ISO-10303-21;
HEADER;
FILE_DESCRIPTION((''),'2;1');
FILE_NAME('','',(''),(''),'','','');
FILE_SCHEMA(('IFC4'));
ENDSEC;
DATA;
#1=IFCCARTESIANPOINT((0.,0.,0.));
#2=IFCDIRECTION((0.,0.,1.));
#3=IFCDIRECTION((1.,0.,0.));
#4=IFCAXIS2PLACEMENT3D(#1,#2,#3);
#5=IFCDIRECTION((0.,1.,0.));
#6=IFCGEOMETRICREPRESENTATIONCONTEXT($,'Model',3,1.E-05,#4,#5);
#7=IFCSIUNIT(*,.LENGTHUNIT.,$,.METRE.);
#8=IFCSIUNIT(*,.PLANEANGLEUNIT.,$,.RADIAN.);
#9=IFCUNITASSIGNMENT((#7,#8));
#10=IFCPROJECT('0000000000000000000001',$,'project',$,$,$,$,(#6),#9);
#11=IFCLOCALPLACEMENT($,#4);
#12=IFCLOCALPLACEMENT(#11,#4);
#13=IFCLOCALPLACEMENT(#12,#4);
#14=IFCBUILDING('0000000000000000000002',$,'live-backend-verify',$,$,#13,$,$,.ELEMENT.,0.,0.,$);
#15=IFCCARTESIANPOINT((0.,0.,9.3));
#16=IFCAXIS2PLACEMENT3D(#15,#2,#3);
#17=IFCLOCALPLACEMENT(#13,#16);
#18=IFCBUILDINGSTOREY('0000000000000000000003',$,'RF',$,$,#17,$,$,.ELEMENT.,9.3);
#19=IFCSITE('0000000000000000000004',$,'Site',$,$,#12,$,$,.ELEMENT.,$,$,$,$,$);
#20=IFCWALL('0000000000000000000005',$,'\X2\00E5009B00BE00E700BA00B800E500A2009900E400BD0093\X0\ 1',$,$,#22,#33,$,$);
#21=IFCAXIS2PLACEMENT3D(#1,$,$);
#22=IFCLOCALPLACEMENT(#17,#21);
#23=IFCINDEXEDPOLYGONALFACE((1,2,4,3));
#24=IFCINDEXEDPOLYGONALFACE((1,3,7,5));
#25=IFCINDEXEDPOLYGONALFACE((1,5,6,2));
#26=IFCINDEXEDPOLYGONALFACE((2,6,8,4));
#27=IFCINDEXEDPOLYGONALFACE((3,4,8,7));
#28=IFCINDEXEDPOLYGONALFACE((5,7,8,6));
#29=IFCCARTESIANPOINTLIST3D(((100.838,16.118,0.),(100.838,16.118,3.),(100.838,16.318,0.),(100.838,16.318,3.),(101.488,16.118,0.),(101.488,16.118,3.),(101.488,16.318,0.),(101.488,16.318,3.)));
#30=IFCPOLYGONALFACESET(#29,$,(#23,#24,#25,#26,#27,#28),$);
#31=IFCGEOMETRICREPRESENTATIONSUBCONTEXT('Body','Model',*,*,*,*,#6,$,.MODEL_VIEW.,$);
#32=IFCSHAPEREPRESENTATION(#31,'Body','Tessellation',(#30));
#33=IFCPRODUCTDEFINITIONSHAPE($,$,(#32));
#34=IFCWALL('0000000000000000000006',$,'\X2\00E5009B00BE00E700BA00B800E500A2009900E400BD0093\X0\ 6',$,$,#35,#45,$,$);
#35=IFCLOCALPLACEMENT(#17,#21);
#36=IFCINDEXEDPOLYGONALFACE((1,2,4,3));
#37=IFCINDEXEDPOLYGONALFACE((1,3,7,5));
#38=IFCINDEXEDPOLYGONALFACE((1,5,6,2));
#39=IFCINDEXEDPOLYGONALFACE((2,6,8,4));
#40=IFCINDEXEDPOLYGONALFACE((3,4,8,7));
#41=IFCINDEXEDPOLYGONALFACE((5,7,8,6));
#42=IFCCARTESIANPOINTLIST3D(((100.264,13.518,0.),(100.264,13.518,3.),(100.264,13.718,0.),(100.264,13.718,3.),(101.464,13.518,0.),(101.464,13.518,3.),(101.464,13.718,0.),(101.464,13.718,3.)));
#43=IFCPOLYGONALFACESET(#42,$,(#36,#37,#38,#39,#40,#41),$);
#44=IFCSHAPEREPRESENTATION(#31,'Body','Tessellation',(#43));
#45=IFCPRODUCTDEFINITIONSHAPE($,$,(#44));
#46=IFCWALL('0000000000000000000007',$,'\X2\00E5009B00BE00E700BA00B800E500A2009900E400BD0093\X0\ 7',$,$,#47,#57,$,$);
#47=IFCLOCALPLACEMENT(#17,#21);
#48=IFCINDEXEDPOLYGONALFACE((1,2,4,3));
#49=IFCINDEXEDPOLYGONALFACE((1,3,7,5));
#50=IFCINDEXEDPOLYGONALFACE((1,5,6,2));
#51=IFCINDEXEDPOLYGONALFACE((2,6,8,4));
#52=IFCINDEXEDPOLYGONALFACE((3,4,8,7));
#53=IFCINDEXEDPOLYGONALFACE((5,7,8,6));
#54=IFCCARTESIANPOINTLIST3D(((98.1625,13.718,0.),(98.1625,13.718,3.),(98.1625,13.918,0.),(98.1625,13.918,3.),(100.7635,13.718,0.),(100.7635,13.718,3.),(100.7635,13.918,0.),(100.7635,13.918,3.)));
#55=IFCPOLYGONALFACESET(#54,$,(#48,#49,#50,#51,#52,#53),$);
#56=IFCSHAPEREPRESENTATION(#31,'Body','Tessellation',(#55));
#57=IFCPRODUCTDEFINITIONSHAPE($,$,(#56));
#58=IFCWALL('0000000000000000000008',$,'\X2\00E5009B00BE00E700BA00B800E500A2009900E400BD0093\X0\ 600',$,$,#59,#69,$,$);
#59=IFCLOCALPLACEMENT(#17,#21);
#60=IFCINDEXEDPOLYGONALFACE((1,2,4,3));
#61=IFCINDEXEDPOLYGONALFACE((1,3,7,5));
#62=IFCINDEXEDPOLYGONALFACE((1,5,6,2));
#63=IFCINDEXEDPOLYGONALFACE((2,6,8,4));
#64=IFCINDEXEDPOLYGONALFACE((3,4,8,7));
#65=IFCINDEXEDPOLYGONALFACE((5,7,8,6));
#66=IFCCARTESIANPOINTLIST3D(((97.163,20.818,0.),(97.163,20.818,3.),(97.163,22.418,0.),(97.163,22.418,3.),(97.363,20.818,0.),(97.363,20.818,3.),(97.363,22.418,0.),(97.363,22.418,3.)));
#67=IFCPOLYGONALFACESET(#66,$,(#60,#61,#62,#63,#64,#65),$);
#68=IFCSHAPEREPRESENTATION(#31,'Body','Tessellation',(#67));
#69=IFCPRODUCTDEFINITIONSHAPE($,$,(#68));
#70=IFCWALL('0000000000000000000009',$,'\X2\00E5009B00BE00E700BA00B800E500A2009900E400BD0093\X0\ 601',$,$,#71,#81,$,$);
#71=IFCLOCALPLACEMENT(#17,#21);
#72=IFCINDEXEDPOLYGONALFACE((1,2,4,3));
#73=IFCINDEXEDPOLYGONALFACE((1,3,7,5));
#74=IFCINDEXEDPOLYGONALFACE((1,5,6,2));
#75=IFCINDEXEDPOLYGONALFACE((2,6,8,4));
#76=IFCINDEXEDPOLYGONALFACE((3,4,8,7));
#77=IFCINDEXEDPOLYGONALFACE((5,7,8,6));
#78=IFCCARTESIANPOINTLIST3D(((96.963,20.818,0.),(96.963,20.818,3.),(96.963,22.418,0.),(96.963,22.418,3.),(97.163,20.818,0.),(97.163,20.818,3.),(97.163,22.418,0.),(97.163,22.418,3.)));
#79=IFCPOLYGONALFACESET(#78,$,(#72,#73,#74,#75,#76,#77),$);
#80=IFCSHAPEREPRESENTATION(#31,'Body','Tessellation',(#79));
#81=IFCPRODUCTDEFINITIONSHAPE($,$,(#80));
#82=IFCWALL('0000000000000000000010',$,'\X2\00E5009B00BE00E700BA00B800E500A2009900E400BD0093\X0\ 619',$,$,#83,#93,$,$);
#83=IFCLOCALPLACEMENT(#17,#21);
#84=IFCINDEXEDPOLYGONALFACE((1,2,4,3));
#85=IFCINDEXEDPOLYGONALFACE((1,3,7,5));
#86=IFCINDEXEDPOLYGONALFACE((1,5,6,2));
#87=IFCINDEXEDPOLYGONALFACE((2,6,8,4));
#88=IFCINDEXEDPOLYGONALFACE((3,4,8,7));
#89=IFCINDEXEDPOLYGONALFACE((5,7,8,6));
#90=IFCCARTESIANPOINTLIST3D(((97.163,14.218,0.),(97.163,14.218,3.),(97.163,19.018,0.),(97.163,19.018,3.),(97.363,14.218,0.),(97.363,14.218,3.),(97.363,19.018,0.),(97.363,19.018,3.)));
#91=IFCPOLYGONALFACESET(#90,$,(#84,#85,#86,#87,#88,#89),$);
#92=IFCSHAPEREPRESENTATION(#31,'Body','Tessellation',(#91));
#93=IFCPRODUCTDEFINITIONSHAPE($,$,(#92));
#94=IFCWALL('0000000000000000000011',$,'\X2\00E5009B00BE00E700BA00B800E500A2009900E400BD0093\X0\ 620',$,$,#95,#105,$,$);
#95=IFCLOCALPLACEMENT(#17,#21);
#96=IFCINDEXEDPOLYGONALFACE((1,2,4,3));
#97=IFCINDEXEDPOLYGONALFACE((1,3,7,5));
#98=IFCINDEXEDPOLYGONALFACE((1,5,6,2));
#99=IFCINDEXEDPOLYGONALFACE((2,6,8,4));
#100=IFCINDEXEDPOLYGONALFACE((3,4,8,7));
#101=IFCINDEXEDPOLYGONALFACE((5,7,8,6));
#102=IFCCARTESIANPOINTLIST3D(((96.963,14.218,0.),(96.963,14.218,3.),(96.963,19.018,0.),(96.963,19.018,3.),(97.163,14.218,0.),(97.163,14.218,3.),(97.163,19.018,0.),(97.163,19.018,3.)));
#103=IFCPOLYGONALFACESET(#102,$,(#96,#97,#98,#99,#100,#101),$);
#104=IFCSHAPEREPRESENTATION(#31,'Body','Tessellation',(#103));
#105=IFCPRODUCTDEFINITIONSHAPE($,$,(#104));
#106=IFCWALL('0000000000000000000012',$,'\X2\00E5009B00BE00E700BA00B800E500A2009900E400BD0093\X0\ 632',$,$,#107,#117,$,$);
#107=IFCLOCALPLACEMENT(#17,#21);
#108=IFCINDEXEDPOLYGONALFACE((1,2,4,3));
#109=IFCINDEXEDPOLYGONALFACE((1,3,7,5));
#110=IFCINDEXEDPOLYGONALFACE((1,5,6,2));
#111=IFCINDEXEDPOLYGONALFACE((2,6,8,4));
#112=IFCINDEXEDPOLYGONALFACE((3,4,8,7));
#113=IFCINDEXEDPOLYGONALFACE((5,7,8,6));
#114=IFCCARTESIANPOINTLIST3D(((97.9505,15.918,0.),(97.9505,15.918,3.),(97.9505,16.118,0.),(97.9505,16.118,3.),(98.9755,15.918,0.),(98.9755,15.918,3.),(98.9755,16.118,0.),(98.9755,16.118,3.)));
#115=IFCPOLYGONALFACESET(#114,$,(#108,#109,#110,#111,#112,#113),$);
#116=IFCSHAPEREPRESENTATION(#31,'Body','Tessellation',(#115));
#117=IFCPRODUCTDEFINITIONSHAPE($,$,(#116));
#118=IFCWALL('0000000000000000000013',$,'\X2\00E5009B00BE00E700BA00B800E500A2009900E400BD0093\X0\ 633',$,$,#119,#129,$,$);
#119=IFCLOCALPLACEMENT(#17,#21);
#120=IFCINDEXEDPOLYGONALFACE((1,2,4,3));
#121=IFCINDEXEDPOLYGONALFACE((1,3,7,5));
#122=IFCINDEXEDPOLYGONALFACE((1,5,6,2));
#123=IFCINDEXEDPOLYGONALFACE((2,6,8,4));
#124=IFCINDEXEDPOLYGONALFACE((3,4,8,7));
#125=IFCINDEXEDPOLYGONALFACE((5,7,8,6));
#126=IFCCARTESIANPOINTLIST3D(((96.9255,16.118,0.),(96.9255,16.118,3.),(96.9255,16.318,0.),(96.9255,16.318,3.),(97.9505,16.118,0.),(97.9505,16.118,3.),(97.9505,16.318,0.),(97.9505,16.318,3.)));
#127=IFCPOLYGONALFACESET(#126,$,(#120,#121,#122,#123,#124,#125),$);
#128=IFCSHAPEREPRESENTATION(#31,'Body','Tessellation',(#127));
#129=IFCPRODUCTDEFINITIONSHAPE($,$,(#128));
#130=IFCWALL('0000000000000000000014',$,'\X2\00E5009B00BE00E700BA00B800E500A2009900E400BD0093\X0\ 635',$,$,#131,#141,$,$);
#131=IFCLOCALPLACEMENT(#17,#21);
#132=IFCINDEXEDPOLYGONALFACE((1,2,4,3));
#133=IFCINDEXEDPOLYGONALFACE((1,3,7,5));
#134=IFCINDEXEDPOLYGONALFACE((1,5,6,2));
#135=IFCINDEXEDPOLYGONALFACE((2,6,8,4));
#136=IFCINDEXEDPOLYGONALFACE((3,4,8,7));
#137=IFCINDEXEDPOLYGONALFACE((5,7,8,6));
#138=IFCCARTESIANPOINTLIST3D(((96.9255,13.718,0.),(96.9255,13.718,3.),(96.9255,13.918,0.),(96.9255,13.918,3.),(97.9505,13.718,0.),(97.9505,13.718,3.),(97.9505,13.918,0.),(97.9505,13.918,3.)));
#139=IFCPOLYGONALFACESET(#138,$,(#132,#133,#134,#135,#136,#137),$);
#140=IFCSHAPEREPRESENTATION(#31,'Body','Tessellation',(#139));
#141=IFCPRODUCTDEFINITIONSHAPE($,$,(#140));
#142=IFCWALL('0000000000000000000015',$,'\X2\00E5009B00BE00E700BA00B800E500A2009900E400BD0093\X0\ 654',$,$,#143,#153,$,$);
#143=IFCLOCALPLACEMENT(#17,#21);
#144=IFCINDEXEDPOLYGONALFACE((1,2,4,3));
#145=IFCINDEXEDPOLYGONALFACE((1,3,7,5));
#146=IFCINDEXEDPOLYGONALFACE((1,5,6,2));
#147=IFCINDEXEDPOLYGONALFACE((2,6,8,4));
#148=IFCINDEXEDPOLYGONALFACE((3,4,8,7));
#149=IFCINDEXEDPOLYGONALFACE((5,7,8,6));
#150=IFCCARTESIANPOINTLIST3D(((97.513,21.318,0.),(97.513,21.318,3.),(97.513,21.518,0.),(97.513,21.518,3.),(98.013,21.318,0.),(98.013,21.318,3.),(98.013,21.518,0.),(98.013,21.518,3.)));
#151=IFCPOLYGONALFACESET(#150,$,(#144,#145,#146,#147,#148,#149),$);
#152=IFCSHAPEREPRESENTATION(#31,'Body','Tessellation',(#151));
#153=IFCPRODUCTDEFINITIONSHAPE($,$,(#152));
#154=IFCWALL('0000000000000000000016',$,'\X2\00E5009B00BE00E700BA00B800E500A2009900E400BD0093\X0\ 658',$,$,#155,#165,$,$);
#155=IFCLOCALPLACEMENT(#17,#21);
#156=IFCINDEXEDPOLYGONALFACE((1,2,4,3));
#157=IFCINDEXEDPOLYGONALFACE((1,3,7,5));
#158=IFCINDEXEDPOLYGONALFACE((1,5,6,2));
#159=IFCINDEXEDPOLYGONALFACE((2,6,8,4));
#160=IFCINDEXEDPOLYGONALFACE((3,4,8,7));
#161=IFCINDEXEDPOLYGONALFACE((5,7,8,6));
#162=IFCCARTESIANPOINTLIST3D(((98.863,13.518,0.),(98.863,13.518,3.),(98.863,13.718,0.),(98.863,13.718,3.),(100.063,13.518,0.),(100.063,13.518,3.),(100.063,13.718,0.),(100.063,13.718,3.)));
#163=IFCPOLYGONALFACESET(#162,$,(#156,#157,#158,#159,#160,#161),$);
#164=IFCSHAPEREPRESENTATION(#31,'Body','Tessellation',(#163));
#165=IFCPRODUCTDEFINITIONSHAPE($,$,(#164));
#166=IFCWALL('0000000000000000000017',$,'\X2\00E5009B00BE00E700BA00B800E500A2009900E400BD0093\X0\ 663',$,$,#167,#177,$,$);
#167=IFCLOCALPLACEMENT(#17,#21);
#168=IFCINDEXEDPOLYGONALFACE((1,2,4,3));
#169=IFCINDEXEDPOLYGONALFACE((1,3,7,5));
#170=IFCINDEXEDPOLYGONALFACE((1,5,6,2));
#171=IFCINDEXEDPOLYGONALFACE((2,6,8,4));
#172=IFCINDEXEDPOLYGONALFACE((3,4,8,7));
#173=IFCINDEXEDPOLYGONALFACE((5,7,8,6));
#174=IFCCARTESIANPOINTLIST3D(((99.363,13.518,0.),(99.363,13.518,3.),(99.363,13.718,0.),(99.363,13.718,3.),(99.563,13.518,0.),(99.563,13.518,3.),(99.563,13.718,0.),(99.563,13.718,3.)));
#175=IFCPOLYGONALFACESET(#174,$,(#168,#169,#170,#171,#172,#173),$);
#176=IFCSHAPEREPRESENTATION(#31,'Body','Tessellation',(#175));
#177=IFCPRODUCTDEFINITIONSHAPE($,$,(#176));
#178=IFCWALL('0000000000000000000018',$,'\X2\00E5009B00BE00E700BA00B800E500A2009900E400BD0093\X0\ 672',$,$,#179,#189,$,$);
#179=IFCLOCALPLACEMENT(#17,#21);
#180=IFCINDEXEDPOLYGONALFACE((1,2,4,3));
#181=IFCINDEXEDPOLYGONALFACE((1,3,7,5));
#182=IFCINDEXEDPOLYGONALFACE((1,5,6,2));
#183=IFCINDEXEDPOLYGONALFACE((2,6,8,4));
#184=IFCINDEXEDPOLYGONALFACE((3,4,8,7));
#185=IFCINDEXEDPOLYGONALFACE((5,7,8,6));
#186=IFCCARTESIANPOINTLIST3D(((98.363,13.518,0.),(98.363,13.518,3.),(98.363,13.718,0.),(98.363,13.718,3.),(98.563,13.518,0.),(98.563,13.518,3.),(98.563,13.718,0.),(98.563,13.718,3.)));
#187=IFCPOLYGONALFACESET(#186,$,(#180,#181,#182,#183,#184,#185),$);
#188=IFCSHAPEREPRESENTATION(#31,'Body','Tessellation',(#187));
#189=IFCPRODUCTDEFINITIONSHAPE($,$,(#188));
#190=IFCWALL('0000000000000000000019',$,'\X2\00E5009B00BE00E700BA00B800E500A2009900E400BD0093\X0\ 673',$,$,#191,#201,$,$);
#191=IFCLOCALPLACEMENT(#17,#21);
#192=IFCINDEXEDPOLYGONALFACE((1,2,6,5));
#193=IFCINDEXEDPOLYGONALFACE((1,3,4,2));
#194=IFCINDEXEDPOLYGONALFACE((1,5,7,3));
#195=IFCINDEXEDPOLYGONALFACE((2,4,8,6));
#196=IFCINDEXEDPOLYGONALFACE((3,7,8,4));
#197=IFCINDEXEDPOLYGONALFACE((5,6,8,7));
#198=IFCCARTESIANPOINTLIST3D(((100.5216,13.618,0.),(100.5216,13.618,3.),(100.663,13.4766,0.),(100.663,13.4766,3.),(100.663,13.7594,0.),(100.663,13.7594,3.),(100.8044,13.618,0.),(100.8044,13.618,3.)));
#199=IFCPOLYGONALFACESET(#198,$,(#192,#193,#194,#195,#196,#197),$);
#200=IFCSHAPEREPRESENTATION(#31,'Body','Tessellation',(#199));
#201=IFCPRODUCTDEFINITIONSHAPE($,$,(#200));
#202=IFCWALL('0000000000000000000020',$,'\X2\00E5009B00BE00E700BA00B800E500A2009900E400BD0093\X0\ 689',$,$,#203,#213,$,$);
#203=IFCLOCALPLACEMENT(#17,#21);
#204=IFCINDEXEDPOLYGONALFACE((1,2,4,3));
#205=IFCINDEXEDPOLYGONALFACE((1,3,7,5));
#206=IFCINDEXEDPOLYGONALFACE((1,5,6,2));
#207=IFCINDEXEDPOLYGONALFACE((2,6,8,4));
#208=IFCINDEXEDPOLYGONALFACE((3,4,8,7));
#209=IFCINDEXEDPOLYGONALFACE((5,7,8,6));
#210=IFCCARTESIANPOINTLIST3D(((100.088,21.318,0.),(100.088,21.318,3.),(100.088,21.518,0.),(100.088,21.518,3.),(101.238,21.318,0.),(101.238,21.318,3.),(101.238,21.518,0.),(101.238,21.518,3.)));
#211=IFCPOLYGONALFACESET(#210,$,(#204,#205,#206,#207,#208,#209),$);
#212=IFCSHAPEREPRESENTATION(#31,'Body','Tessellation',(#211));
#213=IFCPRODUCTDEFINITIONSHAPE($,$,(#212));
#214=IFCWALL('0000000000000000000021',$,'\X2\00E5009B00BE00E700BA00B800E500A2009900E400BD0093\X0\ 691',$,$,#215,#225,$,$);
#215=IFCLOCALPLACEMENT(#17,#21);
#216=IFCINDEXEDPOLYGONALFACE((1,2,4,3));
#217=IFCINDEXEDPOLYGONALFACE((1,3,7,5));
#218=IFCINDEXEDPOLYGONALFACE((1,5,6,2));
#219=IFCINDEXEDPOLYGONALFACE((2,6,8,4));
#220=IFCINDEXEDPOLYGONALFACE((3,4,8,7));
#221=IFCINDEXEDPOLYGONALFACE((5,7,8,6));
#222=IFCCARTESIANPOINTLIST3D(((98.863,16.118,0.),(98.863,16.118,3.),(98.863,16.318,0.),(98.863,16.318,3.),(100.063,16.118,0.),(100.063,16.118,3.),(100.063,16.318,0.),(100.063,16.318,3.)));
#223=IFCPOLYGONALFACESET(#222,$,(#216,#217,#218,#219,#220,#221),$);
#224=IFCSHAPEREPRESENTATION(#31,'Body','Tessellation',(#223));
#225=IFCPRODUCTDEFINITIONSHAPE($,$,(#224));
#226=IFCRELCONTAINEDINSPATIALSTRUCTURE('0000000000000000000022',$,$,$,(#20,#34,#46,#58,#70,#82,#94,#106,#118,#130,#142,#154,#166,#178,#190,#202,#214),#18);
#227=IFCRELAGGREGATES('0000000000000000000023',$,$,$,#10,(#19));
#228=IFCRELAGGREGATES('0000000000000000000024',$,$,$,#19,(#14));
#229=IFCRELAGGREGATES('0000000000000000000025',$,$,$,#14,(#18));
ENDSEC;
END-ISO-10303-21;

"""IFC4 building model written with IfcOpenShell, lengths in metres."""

from ifc_helpers import new_model, si_unit, direction, frame, frame_2d, origin_with_axes, place, context, subcontext, project, spatial, rectangle, extrude, element, save


model = new_model("IFC4")

# Units and contexts
model_context = context("Model", 3, precision=1e-05, world=origin_with_axes(), true_north=direction((0.0, 1.0, 0.0)))
body_context = subcontext(model_context, "Body", "Model", "MODEL_VIEW")
ifc_project = project(units=[si_unit("LENGTHUNIT", "METRE"), si_unit("PLANEANGLEUNIT", "RADIAN")], contexts=[model_context])

# Site, building, storey
placement = place(None, origin_with_axes())
site_placement = place(placement, origin_with_axes())
site = spatial("IfcSite", under=ifc_project, at=site_placement, Name="Site", CompositionType="ELEMENT")
building_placement = place(site_placement, origin_with_axes())
building = spatial("IfcBuilding", under=site, at=building_placement, Name="live-backend-verify", CompositionType="ELEMENT", ElevationOfRefHeight=0.0, ElevationOfTerrain=0.0)
storey_placement = place(building_placement, frame((0.0, 0.0, 9.3), z_axis=(0.0, 0.0, 1.0), x_axis=(1.0, 0.0, 0.0)))
storey = spatial("IfcBuildingStorey", under=building, at=storey_placement, Name="RF", CompositionType="ELEMENT", Elevation=9.3)

# Walls
wall_1_placement = place(storey_placement, frame((101.163, 16.218, 0.0), z_axis=(0.0, 0.0, 1.0), x_axis=(1.0, 0.0, 0.0)))
element("IfcWall", 1, at=wall_1_placement, inside=storey, Name="å\u009b¾çº¸å¢\u0099ä½\u0093 1", context=body_context, shape_type="SweptSolid", body=[
    extrude(rectangle(XDim=0.65, YDim=0.2, at=frame_2d((0.0, 0.0), x_axis=(1.0, 0.0, 0.0))), frame((0.0, 0.0, 0.0), z_axis=(0.0, 0.0, 1.0)), (0.0, 0.0, 1.0), 3.0),
])
wall_2_placement = place(storey_placement, frame((100.864, 13.618, 0.0), z_axis=(0.0, 0.0, 1.0), x_axis=(1.0, 0.0, 0.0)))
element("IfcWall", 2, at=wall_2_placement, inside=storey, Name="å\u009b¾çº¸å¢\u0099ä½\u0093 6", context=body_context, shape_type="SweptSolid", body=[
    extrude(rectangle(XDim=1.2, YDim=0.2, at=frame_2d((0.0, 0.0), x_axis=(1.0, 0.0, 0.0))), frame((0.0, 0.0, 0.0), z_axis=(0.0, 0.0, 1.0)), (0.0, 0.0, 1.0), 3.0),
])
wall_3_placement = place(storey_placement, frame((99.463, 13.818, 0.0), z_axis=(0.0, 0.0, 1.0), x_axis=(1.0, 0.0, 0.0)))
element("IfcWall", 3, at=wall_3_placement, inside=storey, Name="å\u009b¾çº¸å¢\u0099ä½\u0093 7", context=body_context, shape_type="SweptSolid", body=[
    extrude(rectangle(XDim=2.601, YDim=0.2, at=frame_2d((0.0, 0.0), x_axis=(1.0, 0.0, 0.0))), frame((0.0, 0.0, 0.0), z_axis=(0.0, 0.0, 1.0)), (0.0, 0.0, 1.0), 3.0),
])
for number, where, z_axis, x_axis, name in (
    (4, (97.263, 21.618, 0.0), (0.0, 0.0, 1.0), (0.0, 1.0, 0.0), "å\u009b¾çº¸å¢\u0099ä½\u0093 600"),
    (5, (97.063, 21.618, 0.0), (0.0, 0.0, 1.0), (0.0, 1.0, 0.0), "å\u009b¾çº¸å¢\u0099ä½\u0093 601"),
):
    element("IfcWall", number, at=place(storey_placement, frame(where, z_axis=z_axis, x_axis=x_axis)), inside=storey, Name=name, context=body_context, shape_type="SweptSolid", body=[
        extrude(rectangle(XDim=1.6, YDim=0.2, at=frame_2d((0.0, 0.0), x_axis=(1.0, 0.0, 0.0))), frame((0.0, 0.0, 0.0), z_axis=(0.0, 0.0, 1.0)), (0.0, 0.0, 1.0), 3.0),
    ])
for number, where, z_axis, x_axis, name in (
    (6, (97.263, 16.618, 0.0), (0.0, 0.0, 1.0), (0.0, 1.0, 0.0), "å\u009b¾çº¸å¢\u0099ä½\u0093 619"),
    (7, (97.063, 16.618, 0.0), (0.0, 0.0, 1.0), (0.0, 1.0, 0.0), "å\u009b¾çº¸å¢\u0099ä½\u0093 620"),
):
    element("IfcWall", number, at=place(storey_placement, frame(where, z_axis=z_axis, x_axis=x_axis)), inside=storey, Name=name, context=body_context, shape_type="SweptSolid", body=[
        extrude(rectangle(XDim=4.8, YDim=0.2, at=frame_2d((0.0, 0.0), x_axis=(1.0, 0.0, 0.0))), frame((0.0, 0.0, 0.0), z_axis=(0.0, 0.0, 1.0)), (0.0, 0.0, 1.0), 3.0),
    ])
for number, where, z_axis, x_axis, name in (
    (8, (98.463, 16.018, 0.0), (0.0, 0.0, 1.0), (-1.0, 0.0, 0.0), "å\u009b¾çº¸å¢\u0099ä½\u0093 632"),
    (9, (97.438, 16.218, 0.0), (0.0, 0.0, 1.0), (1.0, 0.0, 0.0), "å\u009b¾çº¸å¢\u0099ä½\u0093 633"),
    (10, (97.438, 13.818, 0.0), (0.0, 0.0, 1.0), (1.0, 0.0, 0.0), "å\u009b¾çº¸å¢\u0099ä½\u0093 635"),
):
    element("IfcWall", number, at=place(storey_placement, frame(where, z_axis=z_axis, x_axis=x_axis)), inside=storey, Name=name, context=body_context, shape_type="SweptSolid", body=[
        extrude(rectangle(XDim=1.025, YDim=0.2, at=frame_2d((0.0, 0.0), x_axis=(1.0, 0.0, 0.0))), frame((0.0, 0.0, 0.0), z_axis=(0.0, 0.0, 1.0)), (0.0, 0.0, 1.0), 3.0),
    ])
wall_4_placement = place(storey_placement, frame((97.763, 21.418, 0.0), z_axis=(0.0, 0.0, 1.0), x_axis=(-1.0, 0.0, 0.0)))
element("IfcWall", 11, at=wall_4_placement, inside=storey, Name="å\u009b¾çº¸å¢\u0099ä½\u0093 654", context=body_context, shape_type="SweptSolid", body=[
    extrude(rectangle(XDim=0.5, YDim=0.2, at=frame_2d((0.0, 0.0), x_axis=(1.0, 0.0, 0.0))), frame((0.0, 0.0, 0.0), z_axis=(0.0, 0.0, 1.0)), (0.0, 0.0, 1.0), 3.0),
])
wall_5_placement = place(storey_placement, frame((99.463, 13.618, 0.0), z_axis=(0.0, 0.0, 1.0), x_axis=(1.0, 0.0, 0.0)))
element("IfcWall", 12, at=wall_5_placement, inside=storey, Name="å\u009b¾çº¸å¢\u0099ä½\u0093 658", context=body_context, shape_type="SweptSolid", body=[
    extrude(rectangle(XDim=1.2, YDim=0.2, at=frame_2d((0.0, 0.0), x_axis=(1.0, 0.0, 0.0))), frame((0.0, 0.0, 0.0), z_axis=(0.0, 0.0, 1.0)), (0.0, 0.0, 1.0), 3.0),
])
for number, where, z_axis, x_axis, name in (
    (13, (99.463, 13.618, 0.0), (0.0, 0.0, 1.0), (0.0, 1.0, 0.0), "å\u009b¾çº¸å¢\u0099ä½\u0093 663"),
    (14, (98.463, 13.618, 0.0), (0.0, 0.0, 1.0), (0.0, 1.0, 0.0), "å\u009b¾çº¸å¢\u0099ä½\u0093 672"),
    (15, (100.663, 13.618, 0.0), (0.0, 0.0, 1.0), (0.707107, -0.707107, 0.0), "å\u009b¾çº¸å¢\u0099ä½\u0093 673"),
):
    element("IfcWall", number, at=place(storey_placement, frame(where, z_axis=z_axis, x_axis=x_axis)), inside=storey, Name=name, context=body_context, shape_type="SweptSolid", body=[
        extrude(rectangle(XDim=0.2, YDim=0.2, at=frame_2d((0.0, 0.0), x_axis=(1.0, 0.0, 0.0))), frame((0.0, 0.0, 0.0), z_axis=(0.0, 0.0, 1.0)), (0.0, 0.0, 1.0), 3.0),
    ])
wall_6_placement = place(storey_placement, frame((100.663, 21.418, 0.0), z_axis=(0.0, 0.0, 1.0), x_axis=(-1.0, 0.0, 0.0)))
element("IfcWall", 16, at=wall_6_placement, inside=storey, Name="å\u009b¾çº¸å¢\u0099ä½\u0093 689", context=body_context, shape_type="SweptSolid", body=[
    extrude(rectangle(XDim=1.15, YDim=0.2, at=frame_2d((0.0, 0.0), x_axis=(1.0, 0.0, 0.0))), frame((0.0, 0.0, 0.0), z_axis=(0.0, 0.0, 1.0)), (0.0, 0.0, 1.0), 3.0),
])
wall_7_placement = place(storey_placement, frame((99.463, 16.218, 0.0), z_axis=(0.0, 0.0, 1.0), x_axis=(1.0, 0.0, 0.0)))
element("IfcWall", 17, at=wall_7_placement, inside=storey, Name="å\u009b¾çº¸å¢\u0099ä½\u0093 691", context=body_context, shape_type="SweptSolid", body=[
    extrude(rectangle(XDim=1.2, YDim=0.2, at=frame_2d((0.0, 0.0), x_axis=(1.0, 0.0, 0.0))), frame((0.0, 0.0, 0.0), z_axis=(0.0, 0.0, 1.0)), (0.0, 0.0, 1.0), 3.0),
])

save(model, "model.ifc")
